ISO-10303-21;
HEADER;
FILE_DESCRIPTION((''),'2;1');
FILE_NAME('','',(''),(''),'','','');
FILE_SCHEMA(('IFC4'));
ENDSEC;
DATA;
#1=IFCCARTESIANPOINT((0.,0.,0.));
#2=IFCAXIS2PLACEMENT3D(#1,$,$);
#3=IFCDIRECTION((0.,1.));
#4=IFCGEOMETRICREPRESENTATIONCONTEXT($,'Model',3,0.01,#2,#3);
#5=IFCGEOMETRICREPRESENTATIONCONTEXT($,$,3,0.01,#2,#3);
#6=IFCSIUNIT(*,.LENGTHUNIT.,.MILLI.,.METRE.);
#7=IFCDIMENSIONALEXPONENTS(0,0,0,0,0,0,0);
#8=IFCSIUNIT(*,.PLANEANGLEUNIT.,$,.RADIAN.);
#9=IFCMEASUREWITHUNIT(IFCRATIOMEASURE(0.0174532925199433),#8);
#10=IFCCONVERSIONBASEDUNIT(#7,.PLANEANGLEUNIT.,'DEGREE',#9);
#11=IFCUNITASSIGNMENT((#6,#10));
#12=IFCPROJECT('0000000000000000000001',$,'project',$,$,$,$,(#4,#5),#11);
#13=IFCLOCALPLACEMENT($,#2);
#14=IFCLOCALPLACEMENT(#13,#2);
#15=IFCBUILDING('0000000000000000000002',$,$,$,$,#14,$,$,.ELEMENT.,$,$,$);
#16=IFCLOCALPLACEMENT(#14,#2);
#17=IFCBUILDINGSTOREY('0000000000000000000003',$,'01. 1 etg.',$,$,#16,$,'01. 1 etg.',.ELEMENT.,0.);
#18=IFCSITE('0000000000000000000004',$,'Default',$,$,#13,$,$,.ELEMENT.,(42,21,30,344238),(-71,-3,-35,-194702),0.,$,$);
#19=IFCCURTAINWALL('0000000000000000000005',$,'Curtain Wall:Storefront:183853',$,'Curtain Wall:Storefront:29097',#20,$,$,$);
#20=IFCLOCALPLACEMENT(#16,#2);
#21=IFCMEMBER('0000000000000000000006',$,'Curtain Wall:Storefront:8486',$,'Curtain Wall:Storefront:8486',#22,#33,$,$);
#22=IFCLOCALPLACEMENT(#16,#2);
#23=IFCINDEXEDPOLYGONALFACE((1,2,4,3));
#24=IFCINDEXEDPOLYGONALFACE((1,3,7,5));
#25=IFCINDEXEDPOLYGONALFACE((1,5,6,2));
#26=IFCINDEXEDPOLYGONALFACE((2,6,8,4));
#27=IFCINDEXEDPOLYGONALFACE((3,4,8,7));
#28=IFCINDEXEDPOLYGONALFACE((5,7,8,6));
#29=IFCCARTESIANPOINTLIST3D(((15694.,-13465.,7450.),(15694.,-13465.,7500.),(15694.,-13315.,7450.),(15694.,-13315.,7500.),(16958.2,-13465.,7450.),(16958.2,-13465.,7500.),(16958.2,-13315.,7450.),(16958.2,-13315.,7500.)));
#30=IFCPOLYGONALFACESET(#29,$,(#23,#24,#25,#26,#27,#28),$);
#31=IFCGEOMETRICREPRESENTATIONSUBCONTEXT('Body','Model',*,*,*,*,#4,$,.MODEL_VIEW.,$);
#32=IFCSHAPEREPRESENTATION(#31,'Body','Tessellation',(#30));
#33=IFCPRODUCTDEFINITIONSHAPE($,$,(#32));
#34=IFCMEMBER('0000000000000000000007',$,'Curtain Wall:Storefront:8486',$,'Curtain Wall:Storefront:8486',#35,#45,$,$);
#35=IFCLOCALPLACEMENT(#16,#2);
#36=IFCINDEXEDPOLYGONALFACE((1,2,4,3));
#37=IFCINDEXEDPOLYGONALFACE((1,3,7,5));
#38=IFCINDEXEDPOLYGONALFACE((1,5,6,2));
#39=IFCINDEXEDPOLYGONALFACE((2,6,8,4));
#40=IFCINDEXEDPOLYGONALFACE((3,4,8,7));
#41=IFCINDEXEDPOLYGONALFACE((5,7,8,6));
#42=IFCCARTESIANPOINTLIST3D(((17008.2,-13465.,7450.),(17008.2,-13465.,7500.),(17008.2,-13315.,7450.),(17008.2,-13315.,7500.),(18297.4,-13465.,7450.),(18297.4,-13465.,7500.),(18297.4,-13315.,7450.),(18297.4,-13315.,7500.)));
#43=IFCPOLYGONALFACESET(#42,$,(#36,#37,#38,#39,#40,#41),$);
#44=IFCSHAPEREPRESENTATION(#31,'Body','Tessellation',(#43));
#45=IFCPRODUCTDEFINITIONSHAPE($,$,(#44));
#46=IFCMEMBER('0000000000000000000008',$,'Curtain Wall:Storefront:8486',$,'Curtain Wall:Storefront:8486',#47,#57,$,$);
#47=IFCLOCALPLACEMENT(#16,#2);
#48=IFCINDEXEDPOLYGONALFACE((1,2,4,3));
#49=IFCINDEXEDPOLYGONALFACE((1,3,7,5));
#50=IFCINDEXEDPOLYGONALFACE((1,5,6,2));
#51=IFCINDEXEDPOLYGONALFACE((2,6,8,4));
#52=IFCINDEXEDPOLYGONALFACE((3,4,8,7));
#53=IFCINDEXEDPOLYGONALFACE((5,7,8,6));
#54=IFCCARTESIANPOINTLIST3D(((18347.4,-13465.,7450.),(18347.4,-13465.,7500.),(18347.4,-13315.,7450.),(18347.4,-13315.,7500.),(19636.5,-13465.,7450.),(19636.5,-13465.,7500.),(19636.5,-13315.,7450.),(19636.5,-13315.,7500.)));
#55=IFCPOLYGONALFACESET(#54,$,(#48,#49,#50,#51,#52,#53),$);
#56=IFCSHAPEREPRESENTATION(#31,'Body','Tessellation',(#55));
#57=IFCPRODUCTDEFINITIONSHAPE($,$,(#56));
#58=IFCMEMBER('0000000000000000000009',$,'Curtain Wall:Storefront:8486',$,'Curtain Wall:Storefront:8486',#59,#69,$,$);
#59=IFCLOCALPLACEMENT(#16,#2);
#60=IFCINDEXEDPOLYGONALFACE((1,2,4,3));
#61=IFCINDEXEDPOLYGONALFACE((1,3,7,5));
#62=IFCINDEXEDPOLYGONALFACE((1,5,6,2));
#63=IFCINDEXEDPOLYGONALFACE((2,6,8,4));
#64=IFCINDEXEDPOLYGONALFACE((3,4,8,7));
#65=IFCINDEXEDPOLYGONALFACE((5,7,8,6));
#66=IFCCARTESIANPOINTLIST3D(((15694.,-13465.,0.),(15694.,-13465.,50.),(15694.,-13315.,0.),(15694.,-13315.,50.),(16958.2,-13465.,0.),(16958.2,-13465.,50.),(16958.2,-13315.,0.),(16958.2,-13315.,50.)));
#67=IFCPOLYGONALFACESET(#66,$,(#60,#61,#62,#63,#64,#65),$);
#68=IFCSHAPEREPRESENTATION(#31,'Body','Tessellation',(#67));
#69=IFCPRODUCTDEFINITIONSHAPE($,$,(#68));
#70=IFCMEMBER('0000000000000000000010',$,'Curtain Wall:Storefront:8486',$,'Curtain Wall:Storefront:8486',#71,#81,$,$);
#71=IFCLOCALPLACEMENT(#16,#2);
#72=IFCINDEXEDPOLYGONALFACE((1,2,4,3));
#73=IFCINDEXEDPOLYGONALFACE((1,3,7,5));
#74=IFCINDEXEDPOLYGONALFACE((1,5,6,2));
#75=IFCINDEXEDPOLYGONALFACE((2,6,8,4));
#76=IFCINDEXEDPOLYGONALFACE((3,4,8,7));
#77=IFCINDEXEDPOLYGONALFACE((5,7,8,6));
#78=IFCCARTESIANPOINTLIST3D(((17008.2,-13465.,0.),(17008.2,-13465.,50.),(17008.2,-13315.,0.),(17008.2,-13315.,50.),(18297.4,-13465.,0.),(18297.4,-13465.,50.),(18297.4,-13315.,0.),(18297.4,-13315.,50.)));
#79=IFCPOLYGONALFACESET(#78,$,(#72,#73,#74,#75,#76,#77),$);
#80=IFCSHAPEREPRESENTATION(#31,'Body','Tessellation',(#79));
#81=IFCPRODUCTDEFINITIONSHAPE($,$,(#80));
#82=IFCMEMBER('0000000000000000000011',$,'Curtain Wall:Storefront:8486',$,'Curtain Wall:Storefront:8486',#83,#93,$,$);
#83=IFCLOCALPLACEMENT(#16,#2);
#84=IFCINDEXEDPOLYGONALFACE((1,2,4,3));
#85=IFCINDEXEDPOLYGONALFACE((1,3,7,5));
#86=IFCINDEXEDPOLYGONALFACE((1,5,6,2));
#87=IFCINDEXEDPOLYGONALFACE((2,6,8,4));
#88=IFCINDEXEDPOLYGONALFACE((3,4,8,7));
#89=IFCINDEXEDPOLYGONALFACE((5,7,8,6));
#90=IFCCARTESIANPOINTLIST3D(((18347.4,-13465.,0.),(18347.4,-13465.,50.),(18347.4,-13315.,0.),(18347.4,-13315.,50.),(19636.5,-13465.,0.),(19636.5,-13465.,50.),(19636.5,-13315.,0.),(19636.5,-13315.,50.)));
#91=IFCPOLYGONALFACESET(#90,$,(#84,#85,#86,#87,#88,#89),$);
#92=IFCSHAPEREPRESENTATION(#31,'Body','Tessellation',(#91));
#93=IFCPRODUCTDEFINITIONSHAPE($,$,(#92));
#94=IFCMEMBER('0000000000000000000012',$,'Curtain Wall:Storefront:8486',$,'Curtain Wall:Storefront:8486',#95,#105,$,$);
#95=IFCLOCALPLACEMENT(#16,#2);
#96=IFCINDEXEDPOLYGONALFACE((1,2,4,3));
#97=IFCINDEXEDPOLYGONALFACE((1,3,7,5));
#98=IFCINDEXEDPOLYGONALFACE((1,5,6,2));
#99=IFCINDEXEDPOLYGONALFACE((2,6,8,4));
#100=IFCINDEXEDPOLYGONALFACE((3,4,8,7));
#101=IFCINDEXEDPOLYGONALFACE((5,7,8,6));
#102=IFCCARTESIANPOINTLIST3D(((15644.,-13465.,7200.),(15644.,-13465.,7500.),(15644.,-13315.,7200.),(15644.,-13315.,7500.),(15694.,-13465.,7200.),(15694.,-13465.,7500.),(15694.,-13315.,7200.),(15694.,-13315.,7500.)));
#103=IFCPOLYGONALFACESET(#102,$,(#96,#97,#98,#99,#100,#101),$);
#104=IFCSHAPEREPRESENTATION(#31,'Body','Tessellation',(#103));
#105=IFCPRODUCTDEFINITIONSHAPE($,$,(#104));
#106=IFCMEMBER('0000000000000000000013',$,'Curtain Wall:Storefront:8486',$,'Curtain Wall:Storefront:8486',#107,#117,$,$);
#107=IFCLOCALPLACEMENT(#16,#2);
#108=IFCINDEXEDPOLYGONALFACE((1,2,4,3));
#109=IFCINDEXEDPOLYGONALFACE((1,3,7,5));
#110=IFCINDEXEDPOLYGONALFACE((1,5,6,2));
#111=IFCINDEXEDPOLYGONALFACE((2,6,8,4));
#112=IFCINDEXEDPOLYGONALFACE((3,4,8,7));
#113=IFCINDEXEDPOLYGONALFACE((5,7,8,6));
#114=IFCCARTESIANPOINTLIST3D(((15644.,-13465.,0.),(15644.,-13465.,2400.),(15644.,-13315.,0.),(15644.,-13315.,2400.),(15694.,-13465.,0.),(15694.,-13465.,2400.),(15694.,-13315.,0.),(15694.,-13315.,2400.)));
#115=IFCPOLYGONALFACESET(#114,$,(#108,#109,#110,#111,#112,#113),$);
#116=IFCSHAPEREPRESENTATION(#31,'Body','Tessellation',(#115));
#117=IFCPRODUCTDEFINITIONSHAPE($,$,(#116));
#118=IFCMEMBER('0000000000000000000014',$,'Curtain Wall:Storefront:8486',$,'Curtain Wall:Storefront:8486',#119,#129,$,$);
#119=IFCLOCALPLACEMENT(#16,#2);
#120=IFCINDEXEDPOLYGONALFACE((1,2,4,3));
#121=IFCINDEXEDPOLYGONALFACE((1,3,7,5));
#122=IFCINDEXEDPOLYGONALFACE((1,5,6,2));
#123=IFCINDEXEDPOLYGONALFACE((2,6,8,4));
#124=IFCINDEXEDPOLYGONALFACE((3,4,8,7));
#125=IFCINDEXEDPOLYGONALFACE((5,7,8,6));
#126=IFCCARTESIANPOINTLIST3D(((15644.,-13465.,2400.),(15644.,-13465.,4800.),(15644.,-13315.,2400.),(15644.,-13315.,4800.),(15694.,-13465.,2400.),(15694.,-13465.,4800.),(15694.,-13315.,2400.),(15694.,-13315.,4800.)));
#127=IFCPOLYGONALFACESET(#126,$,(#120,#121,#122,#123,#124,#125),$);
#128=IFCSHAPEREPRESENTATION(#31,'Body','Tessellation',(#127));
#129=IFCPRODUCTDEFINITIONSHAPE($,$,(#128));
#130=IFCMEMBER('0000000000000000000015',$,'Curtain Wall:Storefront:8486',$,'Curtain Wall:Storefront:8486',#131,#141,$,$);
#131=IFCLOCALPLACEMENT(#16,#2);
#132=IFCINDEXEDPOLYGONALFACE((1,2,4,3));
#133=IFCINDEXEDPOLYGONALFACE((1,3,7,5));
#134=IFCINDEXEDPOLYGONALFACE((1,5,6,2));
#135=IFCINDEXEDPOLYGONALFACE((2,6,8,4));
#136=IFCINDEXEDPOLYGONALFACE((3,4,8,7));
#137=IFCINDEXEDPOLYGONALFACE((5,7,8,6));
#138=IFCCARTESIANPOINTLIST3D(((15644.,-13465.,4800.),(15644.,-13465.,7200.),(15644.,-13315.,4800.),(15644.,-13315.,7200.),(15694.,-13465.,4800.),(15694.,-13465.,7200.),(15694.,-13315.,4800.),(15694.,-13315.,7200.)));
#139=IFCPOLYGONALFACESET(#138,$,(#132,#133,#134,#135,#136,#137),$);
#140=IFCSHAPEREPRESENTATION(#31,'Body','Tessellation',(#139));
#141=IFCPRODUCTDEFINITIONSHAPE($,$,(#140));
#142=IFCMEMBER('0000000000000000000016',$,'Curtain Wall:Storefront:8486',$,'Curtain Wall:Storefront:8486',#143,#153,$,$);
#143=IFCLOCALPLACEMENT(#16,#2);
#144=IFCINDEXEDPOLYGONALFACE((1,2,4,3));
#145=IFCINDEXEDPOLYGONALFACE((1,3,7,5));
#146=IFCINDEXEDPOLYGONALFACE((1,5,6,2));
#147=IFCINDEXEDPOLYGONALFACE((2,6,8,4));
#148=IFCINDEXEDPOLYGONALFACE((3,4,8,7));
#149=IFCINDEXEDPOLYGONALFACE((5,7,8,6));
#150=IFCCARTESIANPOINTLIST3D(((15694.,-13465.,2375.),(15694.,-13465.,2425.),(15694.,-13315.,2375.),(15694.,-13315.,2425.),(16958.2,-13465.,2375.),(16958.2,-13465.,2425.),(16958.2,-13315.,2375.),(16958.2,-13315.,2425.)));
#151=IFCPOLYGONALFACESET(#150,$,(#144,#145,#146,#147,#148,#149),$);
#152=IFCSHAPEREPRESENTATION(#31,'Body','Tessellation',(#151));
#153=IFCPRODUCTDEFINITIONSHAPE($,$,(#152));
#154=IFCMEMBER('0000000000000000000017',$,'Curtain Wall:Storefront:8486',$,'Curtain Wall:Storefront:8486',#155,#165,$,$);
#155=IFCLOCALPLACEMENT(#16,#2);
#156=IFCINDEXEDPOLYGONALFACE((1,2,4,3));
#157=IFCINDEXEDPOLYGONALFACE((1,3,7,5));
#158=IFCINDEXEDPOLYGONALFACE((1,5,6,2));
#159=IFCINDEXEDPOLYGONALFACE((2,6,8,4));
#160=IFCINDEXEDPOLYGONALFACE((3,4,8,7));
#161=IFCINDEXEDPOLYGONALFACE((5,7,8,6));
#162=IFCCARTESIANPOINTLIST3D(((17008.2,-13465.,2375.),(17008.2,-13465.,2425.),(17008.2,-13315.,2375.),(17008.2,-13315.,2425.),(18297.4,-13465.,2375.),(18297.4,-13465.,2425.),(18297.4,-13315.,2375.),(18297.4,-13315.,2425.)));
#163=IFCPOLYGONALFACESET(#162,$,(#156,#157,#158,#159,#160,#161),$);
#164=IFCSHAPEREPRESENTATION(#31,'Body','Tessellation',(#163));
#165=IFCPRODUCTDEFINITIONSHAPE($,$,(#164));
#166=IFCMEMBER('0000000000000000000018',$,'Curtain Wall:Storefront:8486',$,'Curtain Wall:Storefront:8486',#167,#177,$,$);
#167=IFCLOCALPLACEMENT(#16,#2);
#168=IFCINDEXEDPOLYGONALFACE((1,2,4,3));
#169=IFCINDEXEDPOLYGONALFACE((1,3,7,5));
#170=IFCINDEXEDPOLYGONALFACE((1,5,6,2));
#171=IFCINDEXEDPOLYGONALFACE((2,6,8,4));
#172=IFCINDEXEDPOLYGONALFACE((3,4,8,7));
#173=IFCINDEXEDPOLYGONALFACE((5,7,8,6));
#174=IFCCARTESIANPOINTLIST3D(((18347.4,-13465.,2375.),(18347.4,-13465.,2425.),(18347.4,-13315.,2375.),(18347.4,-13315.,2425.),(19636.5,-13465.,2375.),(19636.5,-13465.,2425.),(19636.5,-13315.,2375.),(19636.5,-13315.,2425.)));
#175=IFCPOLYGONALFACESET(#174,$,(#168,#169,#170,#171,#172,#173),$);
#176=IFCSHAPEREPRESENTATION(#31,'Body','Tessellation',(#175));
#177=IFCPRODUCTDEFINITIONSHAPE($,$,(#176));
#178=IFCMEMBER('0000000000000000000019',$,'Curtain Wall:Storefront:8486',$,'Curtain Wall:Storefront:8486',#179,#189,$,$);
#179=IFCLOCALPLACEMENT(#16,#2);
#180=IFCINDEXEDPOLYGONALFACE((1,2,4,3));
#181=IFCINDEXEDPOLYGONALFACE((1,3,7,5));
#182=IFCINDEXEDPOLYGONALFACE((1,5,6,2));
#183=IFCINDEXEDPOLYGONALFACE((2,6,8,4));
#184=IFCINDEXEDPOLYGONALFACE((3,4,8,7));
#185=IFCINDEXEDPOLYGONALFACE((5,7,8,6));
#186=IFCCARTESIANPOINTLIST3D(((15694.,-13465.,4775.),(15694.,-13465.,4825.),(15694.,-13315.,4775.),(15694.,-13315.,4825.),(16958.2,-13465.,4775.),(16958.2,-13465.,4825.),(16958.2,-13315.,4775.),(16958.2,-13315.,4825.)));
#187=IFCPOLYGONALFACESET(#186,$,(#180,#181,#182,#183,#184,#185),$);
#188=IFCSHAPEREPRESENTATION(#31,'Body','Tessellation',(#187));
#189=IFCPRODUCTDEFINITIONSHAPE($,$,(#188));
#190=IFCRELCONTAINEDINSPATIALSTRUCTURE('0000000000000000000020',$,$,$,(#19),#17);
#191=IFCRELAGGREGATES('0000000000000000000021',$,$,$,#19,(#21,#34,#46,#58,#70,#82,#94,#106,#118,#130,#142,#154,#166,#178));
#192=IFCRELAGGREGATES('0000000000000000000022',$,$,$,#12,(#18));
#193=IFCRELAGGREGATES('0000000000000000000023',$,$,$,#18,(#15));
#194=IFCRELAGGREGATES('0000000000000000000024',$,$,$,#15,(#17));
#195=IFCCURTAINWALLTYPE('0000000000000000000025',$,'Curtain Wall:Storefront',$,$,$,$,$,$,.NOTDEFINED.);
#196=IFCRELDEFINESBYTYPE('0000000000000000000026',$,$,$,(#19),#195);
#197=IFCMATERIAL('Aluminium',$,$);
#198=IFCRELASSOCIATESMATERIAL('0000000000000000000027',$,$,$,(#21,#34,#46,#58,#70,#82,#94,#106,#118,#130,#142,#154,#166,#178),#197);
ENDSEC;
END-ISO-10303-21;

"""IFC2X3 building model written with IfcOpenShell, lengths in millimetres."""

from ifc_helpers import new_model, entity, si_unit, converted_unit, direction, frame, frame_2d, origin, origin_2d_with_axis, place, context, subcontext, project, spatial, rectangle, extrude, material, type_object, element, aggregate, save


model = new_model("IFC2X3")

# Units and contexts
model_context = context("Model", 3, precision=0.01, world=origin(), true_north=direction((0.0, 1.0)))
context_of_model = context(None, 3, precision=0.01, world=origin(), true_north=direction((0.0, 1.0)))
body_context = subcontext(model_context, "Body", "Model", "MODEL_VIEW")
ifc_project = project(units=[si_unit("LENGTHUNIT", "METRE", prefix="MILLI"), converted_unit("PLANEANGLEUNIT", "DEGREE", entity("IfcRatioMeasure", 0.0174532925199433), si_unit("PLANEANGLEUNIT", "RADIAN"), dimensions=[0, 0, 0, 0, 0, 0, 0])], contexts=[model_context, context_of_model])

# Site, building, storey
site_placement = place(None, origin())
site = spatial("IfcSite", under=ifc_project, at=site_placement, Name="Default", CompositionType="ELEMENT", RefLatitude=(42, 21, 30, 344238), RefLongitude=(-71, -3, -35, -194702), RefElevation=0.0)
building_placement = place(site_placement, origin())
building = spatial("IfcBuilding", under=site, at=building_placement, CompositionType="ELEMENT")
storey_placement = place(building_placement, origin())
storey = spatial("IfcBuildingStorey", under=building, at=storey_placement, Name="01. 1 etg.", LongName="01. 1 etg.", CompositionType="ELEMENT", Elevation=0.0)

# Curtain wall, members
curtain_wall_type = type_object("IfcCurtainWallType", Name="Curtain Wall:Storefront", PredefinedType="NOTDEFINED")
curtain_wall_placement = place(storey_placement, origin())
curtain_wall = element("IfcCurtainWall", 1, at=curtain_wall_placement, inside=storey, type_object=curtain_wall_type, Name="Curtain Wall:Storefront:183853", ObjectType="Curtain Wall:Storefront:29097")
ifc_material_1 = material(Name="Aluminium")
member_1_placement = place(curtain_wall_placement, frame((15694.0, -13465.0, 7450.0)))
member_1 = element("IfcMember", 2, at=member_1_placement, material=ifc_material_1, Name="Curtain Wall:Storefront:8486", ObjectType="Curtain Wall:Storefront:8486", context=body_context, shape_type="SweptSolid", body=[
    extrude(rectangle(XDim=1264.2, YDim=150.0, at=origin_2d_with_axis()), frame((632.1, 75.0, 0.0), z_axis=(0.0, 0.0, 1.0), x_axis=(-1.0, 0.0, 0.0)), (0.0, 0.0, 1.0), 50.0),
])
member_2_placement = place(curtain_wall_placement, frame((17008.2, -13465.0, 7450.0)))
member_2 = element("IfcMember", 3, at=member_2_placement, material=ifc_material_1, Name="Curtain Wall:Storefront:8486", ObjectType="Curtain Wall:Storefront:8486", context=body_context, shape_type="SweptSolid", body=[
    extrude(rectangle(XDim=1289.2, YDim=150.0, at=frame_2d((0.0, 0.0), x_axis=(1.0, 0.0))), frame((644.6, 75.0, 0.0), z_axis=(0.0, 0.0, 1.0), x_axis=(-1.0, 0.0, 0.0)), (0.0, 0.0, 1.0), 50.0),
])
member_3_placement = place(curtain_wall_placement, frame((18347.4, -13465.0, 7450.0)))
member_3 = element("IfcMember", 4, at=member_3_placement, material=ifc_material_1, Name="Curtain Wall:Storefront:8486", ObjectType="Curtain Wall:Storefront:8486", context=body_context, shape_type="SweptSolid", body=[
    extrude(rectangle(XDim=1289.2, YDim=150.0, at=frame_2d((0.0, 0.0), x_axis=(1.0, 0.0))), frame((644.6, 75.0, 0.0), z_axis=(0.0, 0.0, 1.0), x_axis=(-1.0, 0.0, 0.0)), (0.0, 0.0, 1.0), 50.0),
])
member_4_placement = place(curtain_wall_placement, frame((15694.0, -13465.0, 0.0)))
member_4 = element("IfcMember", 5, at=member_4_placement, material=ifc_material_1, Name="Curtain Wall:Storefront:8486", ObjectType="Curtain Wall:Storefront:8486", context=body_context, shape_type="SweptSolid", body=[
    extrude(rectangle(XDim=1264.2, YDim=150.0, at=origin_2d_with_axis()), frame((632.1, 75.0, 0.0)), (0.0, 0.0, 1.0), 50.0),
])
member_5_placement = place(curtain_wall_placement, frame((17008.2, -13465.0, 0.0)))
member_5 = element("IfcMember", 6, at=member_5_placement, material=ifc_material_1, Name="Curtain Wall:Storefront:8486", ObjectType="Curtain Wall:Storefront:8486", context=body_context, shape_type="SweptSolid", body=[
    extrude(rectangle(XDim=1289.2, YDim=150.0, at=frame_2d((0.0, 0.0), x_axis=(1.0, 0.0))), frame((644.6, 75.0, 0.0)), (0.0, 0.0, 1.0), 50.0),
])
member_6_placement = place(curtain_wall_placement, frame((18347.4, -13465.0, 0.0)))
member_6 = element("IfcMember", 7, at=member_6_placement, material=ifc_material_1, Name="Curtain Wall:Storefront:8486", ObjectType="Curtain Wall:Storefront:8486", context=body_context, shape_type="SweptSolid", body=[
    extrude(rectangle(XDim=1289.2, YDim=150.0, at=frame_2d((0.0, 0.0), x_axis=(1.0, 0.0))), frame((644.6, 75.0, 0.0)), (0.0, 0.0, 1.0), 50.0),
])
member_7_placement = place(curtain_wall_placement, frame((15644.0, -13465.0, 7200.0)))
member_7 = element("IfcMember", 8, at=member_7_placement, material=ifc_material_1, Name="Curtain Wall:Storefront:8486", ObjectType="Curtain Wall:Storefront:8486", context=body_context, shape_type="SweptSolid", body=[
    extrude(rectangle(XDim=50.0, YDim=150.0, at=origin_2d_with_axis()), frame((25.0, 75.0, 0.0)), (0.0, 0.0, 1.0), 300.0),
])
member_8_placement = place(curtain_wall_placement, frame((15644.0, -13465.0, 0.0)))
member_8 = element("IfcMember", 9, at=member_8_placement, material=ifc_material_1, Name="Curtain Wall:Storefront:8486", ObjectType="Curtain Wall:Storefront:8486", context=body_context, shape_type="SweptSolid", body=[
    extrude(rectangle(XDim=50.0, YDim=150.0, at=origin_2d_with_axis()), frame((25.0, 75.0, 0.0)), (0.0, 0.0, 1.0), 2400.0),
])
member_9_placement = place(curtain_wall_placement, frame((15644.0, -13465.0, 2400.0)))
member_9 = element("IfcMember", 10, at=member_9_placement, material=ifc_material_1, Name="Curtain Wall:Storefront:8486", ObjectType="Curtain Wall:Storefront:8486", context=body_context, shape_type="SweptSolid", body=[
    extrude(rectangle(XDim=50.0, YDim=150.0, at=origin_2d_with_axis()), frame((25.0, 75.0, 0.0)), (0.0, 0.0, 1.0), 2400.0),
])
member_10_placement = place(curtain_wall_placement, frame((15644.0, -13465.0, 4800.0)))
member_10 = element("IfcMember", 11, at=member_10_placement, material=ifc_material_1, Name="Curtain Wall:Storefront:8486", ObjectType="Curtain Wall:Storefront:8486", context=body_context, shape_type="SweptSolid", body=[
    extrude(rectangle(XDim=50.0, YDim=150.0, at=origin_2d_with_axis()), frame((25.0, 75.0, 0.0)), (0.0, 0.0, 1.0), 2400.0),
])
member_11_placement = place(curtain_wall_placement, frame((15694.0, -13465.0, 2375.0)))
member_11 = element("IfcMember", 12, at=member_11_placement, material=ifc_material_1, Name="Curtain Wall:Storefront:8486", ObjectType="Curtain Wall:Storefront:8486", context=body_context, shape_type="SweptSolid", body=[
    extrude(rectangle(XDim=1264.2, YDim=150.0, at=frame_2d((0.0, 0.0), x_axis=(1.0, 0.0))), frame((632.1, 75.0, 0.0), z_axis=(0.0, 0.0, 1.0), x_axis=(-1.0, 0.0, 0.0)), (0.0, 0.0, 1.0), 50.0),
])
member_12_placement = place(curtain_wall_placement, frame((17008.2, -13465.0, 2375.0)))
member_12 = element("IfcMember", 13, at=member_12_placement, material=ifc_material_1, Name="Curtain Wall:Storefront:8486", ObjectType="Curtain Wall:Storefront:8486", context=body_context, shape_type="SweptSolid", body=[
    extrude(rectangle(XDim=1289.2, YDim=150.0, at=frame_2d((0.0, 0.0), x_axis=(1.0, 0.0))), frame((644.6, 75.0, 0.0), z_axis=(0.0, 0.0, 1.0), x_axis=(-1.0, 0.0, 0.0)), (0.0, 0.0, 1.0), 50.0),
])
member_13_placement = place(curtain_wall_placement, frame((18347.4, -13465.0, 2375.0)))
member_13 = element("IfcMember", 14, at=member_13_placement, material=ifc_material_1, Name="Curtain Wall:Storefront:8486", ObjectType="Curtain Wall:Storefront:8486", context=body_context, shape_type="SweptSolid", body=[
    extrude(rectangle(XDim=1289.2, YDim=150.0, at=frame_2d((0.0, 0.0), x_axis=(1.0, 0.0))), frame((644.6, 75.0, 0.0), z_axis=(0.0, 0.0, 1.0), x_axis=(-1.0, 0.0, 0.0)), (0.0, 0.0, 1.0), 50.0),
])
member_14_placement = place(curtain_wall_placement, frame((15694.0, -13465.0, 4775.0)))
member_14 = element("IfcMember", 15, at=member_14_placement, material=ifc_material_1, Name="Curtain Wall:Storefront:8486", ObjectType="Curtain Wall:Storefront:8486", context=body_context, shape_type="SweptSolid", body=[
    extrude(rectangle(XDim=1264.2, YDim=150.0, at=frame_2d((0.0, 0.0), x_axis=(1.0, 0.0))), frame((632.1, 75.0, 0.0), z_axis=(0.0, 0.0, 1.0), x_axis=(-1.0, 0.0, 0.0)), (0.0, 0.0, 1.0), 50.0),
])
aggregate(curtain_wall, [member_1, member_2, member_3, member_4, member_5, member_6, member_7, member_8, member_9, member_10, member_11, member_12, member_13, member_14])

save(model, "model.ifc")
